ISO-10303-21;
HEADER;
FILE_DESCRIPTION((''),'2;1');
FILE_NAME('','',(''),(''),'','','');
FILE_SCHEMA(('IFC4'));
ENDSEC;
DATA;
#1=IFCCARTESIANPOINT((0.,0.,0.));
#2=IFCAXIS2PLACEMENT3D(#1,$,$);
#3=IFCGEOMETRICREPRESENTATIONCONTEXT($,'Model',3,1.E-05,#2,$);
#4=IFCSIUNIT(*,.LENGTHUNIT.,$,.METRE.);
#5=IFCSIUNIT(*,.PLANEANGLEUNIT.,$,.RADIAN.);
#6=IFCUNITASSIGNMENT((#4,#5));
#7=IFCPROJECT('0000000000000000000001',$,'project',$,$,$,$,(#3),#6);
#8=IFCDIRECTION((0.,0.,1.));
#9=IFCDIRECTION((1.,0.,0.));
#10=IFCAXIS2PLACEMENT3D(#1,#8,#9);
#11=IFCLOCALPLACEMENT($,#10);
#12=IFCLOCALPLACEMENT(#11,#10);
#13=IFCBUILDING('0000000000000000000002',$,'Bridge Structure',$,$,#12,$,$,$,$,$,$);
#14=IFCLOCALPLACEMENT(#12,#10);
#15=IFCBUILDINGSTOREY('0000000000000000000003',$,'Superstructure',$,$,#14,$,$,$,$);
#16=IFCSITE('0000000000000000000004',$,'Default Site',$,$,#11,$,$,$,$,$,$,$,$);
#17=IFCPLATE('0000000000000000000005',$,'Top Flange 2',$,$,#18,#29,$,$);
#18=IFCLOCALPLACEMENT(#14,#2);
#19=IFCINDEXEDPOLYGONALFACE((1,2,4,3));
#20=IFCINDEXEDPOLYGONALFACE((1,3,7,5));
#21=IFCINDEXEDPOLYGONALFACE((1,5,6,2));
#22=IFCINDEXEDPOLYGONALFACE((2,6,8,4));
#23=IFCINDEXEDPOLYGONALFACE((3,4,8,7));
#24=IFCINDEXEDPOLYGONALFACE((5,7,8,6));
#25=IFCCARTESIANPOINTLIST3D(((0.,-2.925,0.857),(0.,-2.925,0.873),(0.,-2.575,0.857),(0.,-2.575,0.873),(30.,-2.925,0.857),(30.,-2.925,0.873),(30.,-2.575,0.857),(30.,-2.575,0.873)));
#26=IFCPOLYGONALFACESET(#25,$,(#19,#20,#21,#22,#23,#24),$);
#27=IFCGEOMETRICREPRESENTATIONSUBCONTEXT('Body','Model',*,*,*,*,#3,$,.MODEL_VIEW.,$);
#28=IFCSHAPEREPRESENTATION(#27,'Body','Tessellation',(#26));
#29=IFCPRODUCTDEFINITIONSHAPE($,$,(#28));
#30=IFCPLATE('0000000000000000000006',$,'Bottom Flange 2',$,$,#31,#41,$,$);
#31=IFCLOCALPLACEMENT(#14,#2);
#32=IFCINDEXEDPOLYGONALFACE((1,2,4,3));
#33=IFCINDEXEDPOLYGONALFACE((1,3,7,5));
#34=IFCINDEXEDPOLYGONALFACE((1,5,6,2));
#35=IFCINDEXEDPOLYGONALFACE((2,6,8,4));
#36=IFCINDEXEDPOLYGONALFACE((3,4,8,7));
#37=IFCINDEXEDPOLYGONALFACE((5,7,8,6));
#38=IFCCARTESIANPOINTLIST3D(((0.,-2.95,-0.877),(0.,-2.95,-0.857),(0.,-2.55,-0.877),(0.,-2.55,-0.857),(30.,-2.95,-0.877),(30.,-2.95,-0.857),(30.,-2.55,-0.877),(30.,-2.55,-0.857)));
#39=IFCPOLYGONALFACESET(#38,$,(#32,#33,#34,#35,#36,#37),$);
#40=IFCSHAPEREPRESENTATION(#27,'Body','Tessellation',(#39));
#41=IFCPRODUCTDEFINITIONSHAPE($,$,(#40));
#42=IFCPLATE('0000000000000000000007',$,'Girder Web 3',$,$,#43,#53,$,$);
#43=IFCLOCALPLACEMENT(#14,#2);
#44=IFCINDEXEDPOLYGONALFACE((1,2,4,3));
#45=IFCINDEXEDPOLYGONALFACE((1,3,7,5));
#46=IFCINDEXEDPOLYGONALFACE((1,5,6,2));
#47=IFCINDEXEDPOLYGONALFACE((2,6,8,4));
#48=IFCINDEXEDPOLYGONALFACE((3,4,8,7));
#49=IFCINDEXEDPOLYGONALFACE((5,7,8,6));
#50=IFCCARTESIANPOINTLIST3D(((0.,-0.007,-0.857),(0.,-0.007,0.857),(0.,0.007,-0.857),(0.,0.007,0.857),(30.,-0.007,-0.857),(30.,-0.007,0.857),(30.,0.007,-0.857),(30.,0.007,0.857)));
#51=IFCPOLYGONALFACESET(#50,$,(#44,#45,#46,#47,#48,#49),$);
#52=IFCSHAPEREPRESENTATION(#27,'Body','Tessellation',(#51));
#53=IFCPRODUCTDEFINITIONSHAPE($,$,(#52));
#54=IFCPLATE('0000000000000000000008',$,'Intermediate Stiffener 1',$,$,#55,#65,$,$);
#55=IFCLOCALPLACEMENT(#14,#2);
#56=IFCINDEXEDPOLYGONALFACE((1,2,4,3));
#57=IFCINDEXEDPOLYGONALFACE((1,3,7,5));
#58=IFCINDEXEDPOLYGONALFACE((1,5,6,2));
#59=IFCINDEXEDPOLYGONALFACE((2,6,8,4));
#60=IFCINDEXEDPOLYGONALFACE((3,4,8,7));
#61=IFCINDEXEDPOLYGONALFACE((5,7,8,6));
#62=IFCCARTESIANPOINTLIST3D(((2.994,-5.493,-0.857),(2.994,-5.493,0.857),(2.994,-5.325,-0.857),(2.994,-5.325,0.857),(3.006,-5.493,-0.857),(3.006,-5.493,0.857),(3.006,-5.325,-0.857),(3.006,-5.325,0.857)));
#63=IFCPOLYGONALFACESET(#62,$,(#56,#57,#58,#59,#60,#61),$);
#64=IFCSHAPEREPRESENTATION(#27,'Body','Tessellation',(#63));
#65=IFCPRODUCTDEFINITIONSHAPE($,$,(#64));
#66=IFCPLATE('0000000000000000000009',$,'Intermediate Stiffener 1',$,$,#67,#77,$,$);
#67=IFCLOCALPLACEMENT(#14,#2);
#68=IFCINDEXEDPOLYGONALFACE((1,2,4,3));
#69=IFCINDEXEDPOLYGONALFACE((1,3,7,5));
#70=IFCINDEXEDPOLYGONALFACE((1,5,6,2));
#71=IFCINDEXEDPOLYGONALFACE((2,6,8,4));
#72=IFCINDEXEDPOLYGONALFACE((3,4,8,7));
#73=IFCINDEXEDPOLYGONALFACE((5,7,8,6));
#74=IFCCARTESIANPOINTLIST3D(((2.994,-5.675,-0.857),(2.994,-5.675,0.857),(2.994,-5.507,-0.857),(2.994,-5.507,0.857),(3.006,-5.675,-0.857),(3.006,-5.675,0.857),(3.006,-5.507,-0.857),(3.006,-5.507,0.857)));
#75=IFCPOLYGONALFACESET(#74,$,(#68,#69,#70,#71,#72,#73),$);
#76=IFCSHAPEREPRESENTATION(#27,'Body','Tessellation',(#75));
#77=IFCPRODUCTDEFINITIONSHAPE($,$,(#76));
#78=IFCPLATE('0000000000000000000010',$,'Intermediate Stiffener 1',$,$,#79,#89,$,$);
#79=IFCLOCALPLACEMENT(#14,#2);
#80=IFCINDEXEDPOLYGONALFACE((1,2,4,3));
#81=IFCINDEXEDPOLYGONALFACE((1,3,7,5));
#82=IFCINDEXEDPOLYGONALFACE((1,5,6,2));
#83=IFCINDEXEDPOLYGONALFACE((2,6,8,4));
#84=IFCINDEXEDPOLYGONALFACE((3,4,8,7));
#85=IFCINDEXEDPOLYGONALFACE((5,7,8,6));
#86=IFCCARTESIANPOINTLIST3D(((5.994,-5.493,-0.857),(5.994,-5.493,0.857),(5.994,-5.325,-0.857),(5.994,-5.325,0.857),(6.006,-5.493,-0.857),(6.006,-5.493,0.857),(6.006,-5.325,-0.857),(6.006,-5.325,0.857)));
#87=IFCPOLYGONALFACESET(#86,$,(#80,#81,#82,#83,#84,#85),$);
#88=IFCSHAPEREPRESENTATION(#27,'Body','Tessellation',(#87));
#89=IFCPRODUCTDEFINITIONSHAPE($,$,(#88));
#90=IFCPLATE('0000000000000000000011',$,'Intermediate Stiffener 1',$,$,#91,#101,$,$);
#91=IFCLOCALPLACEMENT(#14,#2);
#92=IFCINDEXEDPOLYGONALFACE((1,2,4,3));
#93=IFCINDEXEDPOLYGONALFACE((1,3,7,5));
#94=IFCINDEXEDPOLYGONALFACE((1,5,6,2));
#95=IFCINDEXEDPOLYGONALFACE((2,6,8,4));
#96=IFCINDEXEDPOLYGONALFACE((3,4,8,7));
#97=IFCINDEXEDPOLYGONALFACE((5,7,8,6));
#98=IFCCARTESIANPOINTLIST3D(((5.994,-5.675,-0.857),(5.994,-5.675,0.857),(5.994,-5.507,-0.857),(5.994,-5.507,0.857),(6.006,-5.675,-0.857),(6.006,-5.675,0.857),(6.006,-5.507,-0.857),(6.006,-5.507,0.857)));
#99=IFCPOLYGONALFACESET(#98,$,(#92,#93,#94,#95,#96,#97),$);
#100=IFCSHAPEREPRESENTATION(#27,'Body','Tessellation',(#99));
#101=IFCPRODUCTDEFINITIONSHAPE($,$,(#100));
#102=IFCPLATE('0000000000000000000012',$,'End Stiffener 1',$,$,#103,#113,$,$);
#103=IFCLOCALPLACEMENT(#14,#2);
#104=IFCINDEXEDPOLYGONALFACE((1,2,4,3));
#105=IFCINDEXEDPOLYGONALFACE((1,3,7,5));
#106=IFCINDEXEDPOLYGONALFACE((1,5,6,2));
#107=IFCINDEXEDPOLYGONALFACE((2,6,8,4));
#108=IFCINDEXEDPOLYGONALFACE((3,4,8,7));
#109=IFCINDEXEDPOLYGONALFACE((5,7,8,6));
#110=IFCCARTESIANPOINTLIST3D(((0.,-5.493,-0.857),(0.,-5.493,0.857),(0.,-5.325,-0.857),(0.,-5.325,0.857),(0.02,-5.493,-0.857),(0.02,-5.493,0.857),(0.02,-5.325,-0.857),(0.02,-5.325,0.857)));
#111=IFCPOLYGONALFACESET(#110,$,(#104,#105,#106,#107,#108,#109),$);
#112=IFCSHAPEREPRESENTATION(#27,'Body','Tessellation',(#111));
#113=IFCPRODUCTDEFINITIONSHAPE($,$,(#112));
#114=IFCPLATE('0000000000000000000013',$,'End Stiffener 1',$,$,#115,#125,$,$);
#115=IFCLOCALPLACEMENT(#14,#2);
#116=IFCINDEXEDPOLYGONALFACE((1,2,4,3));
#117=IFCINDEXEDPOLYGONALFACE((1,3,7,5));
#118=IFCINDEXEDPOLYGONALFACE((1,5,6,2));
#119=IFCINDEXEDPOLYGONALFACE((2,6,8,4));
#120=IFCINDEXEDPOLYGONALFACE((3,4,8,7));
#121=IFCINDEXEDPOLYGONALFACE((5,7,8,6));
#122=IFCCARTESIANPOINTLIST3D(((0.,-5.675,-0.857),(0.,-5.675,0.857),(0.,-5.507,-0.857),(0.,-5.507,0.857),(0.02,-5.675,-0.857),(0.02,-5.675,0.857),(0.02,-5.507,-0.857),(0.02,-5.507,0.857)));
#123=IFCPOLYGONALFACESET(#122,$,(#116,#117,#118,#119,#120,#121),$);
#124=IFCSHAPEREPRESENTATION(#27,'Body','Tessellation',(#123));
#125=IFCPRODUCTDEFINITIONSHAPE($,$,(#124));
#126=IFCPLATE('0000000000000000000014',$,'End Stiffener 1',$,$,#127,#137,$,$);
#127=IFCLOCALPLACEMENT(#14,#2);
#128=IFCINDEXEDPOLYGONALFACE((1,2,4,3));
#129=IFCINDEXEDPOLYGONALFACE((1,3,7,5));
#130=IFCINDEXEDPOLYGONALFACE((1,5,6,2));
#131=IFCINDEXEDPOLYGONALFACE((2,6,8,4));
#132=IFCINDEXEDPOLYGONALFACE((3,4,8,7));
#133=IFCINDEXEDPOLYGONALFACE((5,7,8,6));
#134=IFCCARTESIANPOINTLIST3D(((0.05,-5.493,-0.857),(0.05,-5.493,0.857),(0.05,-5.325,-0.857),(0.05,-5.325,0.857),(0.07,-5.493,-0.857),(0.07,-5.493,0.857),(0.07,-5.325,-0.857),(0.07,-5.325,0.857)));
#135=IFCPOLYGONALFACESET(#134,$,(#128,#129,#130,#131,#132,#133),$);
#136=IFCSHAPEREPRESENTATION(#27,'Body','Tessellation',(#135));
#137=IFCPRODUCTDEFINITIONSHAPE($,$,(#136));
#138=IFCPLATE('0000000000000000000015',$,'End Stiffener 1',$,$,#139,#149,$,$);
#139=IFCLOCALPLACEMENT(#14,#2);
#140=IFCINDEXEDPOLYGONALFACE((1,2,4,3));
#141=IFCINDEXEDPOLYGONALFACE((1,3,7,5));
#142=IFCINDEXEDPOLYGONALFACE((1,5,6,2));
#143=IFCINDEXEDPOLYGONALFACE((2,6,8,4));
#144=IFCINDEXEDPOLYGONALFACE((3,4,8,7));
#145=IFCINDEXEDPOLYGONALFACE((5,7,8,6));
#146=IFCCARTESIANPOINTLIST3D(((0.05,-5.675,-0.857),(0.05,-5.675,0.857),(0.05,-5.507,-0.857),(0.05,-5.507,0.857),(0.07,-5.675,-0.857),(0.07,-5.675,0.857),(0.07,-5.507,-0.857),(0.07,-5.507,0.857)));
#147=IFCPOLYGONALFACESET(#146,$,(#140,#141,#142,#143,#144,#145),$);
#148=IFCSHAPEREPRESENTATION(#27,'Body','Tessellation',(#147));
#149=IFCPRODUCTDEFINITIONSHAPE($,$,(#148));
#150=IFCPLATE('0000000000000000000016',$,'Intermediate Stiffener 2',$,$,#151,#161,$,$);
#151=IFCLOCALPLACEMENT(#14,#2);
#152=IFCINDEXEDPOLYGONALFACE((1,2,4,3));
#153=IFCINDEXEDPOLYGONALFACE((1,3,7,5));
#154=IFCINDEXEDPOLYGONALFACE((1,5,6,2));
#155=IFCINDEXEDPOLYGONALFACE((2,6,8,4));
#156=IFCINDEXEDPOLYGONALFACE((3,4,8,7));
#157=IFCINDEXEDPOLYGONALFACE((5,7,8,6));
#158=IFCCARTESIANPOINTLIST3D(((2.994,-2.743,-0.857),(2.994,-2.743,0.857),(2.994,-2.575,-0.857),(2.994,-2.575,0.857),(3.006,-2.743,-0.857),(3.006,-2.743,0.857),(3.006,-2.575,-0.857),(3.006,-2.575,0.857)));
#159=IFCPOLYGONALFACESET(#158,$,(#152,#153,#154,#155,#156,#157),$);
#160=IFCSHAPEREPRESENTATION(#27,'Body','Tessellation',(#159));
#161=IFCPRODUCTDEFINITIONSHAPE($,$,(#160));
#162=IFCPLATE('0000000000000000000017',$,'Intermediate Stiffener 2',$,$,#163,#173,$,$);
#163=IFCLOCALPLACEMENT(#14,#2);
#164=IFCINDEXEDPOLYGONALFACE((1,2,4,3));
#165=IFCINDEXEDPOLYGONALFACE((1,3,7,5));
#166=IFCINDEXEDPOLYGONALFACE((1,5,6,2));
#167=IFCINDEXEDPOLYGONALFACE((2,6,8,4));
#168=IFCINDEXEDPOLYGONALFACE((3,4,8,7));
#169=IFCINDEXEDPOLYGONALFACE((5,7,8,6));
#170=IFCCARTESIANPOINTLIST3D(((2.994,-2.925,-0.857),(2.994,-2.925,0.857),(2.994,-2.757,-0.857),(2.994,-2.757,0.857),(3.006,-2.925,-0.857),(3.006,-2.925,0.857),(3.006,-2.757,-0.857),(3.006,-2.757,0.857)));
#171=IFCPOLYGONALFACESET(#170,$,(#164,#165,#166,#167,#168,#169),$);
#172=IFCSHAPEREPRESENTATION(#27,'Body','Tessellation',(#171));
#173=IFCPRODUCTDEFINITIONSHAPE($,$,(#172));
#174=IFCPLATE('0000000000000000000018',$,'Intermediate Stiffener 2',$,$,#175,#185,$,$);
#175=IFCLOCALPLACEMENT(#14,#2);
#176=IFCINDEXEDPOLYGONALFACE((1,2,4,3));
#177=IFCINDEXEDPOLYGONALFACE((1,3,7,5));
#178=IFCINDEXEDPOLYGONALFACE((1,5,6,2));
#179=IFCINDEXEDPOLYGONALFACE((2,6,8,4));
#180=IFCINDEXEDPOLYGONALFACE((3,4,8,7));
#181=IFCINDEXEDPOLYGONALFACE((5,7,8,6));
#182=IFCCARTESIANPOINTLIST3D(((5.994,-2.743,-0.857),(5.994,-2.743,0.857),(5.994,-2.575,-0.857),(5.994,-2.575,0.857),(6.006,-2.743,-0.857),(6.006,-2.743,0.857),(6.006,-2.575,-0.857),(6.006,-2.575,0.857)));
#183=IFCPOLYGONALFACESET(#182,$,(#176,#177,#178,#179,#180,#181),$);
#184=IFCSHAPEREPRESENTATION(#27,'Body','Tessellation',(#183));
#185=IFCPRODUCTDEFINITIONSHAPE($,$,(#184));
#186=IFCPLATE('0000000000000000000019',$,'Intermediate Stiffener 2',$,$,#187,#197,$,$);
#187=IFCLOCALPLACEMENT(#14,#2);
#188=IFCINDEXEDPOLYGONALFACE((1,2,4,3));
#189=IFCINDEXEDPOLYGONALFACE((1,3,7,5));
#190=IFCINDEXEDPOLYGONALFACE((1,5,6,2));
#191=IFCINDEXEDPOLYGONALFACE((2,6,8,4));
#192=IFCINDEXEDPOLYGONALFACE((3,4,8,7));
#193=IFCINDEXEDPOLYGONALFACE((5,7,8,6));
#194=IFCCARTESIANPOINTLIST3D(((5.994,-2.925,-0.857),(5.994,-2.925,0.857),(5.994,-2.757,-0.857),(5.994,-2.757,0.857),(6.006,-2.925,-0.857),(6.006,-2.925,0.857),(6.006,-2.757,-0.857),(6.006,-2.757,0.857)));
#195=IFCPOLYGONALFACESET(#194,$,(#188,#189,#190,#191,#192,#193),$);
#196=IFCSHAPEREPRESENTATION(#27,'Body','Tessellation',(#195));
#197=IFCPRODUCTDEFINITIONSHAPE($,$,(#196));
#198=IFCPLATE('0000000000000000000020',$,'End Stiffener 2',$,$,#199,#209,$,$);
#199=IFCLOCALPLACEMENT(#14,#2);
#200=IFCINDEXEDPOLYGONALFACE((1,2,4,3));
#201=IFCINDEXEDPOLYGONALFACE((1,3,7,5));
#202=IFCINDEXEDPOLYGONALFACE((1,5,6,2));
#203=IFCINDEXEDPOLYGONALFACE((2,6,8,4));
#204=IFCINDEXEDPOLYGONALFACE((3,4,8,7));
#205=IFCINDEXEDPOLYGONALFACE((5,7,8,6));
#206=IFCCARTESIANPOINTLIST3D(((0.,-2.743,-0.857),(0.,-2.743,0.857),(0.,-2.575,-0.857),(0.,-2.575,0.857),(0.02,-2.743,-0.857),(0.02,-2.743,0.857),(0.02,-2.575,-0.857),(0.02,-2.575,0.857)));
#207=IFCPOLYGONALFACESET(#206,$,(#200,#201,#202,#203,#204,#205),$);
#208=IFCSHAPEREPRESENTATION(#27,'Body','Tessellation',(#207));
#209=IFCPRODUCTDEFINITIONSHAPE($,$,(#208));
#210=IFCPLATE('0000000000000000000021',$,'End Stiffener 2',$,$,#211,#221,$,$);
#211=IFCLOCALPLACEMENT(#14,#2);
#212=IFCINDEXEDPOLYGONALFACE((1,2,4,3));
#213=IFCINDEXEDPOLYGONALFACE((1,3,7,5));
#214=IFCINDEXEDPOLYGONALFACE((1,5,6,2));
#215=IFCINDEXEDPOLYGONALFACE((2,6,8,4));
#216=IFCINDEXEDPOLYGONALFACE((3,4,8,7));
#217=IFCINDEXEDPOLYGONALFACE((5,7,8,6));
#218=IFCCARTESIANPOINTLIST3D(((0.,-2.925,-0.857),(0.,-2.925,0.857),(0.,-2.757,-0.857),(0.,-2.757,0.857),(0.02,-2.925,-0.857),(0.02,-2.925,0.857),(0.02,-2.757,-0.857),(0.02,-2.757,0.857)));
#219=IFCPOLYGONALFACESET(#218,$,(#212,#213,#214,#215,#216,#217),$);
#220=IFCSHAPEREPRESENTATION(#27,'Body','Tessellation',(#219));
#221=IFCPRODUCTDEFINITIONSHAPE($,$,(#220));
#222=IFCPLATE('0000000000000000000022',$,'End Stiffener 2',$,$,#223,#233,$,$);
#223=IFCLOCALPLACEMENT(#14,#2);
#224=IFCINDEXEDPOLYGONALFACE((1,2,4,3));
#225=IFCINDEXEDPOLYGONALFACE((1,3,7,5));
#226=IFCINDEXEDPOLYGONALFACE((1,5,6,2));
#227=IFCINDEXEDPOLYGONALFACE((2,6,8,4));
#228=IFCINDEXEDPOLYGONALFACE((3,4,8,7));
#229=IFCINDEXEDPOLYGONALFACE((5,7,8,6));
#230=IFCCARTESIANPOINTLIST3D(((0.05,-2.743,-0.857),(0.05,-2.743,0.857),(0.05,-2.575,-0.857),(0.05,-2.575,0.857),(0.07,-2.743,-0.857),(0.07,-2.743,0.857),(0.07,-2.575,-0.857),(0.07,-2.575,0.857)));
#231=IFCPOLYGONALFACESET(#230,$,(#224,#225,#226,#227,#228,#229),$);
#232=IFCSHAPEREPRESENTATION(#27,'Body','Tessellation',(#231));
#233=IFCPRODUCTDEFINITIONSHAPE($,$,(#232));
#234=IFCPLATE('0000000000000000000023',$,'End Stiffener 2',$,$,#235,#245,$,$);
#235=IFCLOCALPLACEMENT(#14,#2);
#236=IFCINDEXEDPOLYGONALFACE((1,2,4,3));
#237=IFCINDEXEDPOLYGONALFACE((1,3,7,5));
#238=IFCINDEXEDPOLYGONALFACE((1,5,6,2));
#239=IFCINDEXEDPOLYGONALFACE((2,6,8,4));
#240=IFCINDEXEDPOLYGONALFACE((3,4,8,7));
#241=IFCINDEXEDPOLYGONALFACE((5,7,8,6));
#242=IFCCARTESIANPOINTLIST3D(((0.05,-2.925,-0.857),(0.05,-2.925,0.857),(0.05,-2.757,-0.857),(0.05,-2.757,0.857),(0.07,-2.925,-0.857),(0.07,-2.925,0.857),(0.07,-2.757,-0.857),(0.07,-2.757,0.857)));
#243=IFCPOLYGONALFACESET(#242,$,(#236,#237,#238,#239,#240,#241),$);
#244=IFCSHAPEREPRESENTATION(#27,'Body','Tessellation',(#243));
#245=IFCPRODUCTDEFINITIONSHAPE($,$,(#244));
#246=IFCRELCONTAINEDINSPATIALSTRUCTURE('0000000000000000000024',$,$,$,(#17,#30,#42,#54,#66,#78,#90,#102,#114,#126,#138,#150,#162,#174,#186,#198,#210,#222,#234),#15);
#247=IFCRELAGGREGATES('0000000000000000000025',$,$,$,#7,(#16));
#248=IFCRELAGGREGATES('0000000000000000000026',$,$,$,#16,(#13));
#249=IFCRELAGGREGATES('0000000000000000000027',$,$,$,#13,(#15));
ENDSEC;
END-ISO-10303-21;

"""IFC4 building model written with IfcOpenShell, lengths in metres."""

from ifc_helpers import new_model, si_unit, frame, origin, origin_with_axes, origin_2d_with_axis, place, context, subcontext, project, spatial, rectangle, extrude, element, save


model = new_model("IFC4")

# Units and contexts
model_context = context("Model", 3, precision=1e-05, world=origin())
body_context = subcontext(model_context, "Body", "Model", "MODEL_VIEW")
ifc_project = project(units=[si_unit("LENGTHUNIT", "METRE"), si_unit("PLANEANGLEUNIT", "RADIAN")], contexts=[model_context])

# Site, building, storey
site_placement = place(None, origin_with_axes())
site = spatial("IfcSite", under=ifc_project, at=site_placement, Name="Default Site")
building_placement = place(site_placement, origin_with_axes())
building = spatial("IfcBuilding", under=site, at=building_placement, Name="Bridge Structure")
storey_placement = place(building_placement, origin_with_axes())
storey = spatial("IfcBuildingStorey", under=building, at=storey_placement, Name="Superstructure")

# Plates
plate_1_placement = place(storey_placement, frame((0.0, -2.75, 0.865), z_axis=(1.0, 0.0, 0.0), x_axis=(0.0, 1.0, 0.0)))
element("IfcPlate", 1, at=plate_1_placement, inside=storey, Name="Top Flange 2", context=body_context, shape_type="SweptSolid", body=[
    extrude(rectangle(XDim=0.35, YDim=0.016, at=origin_2d_with_axis()), origin_with_axes(), (0.0, 0.0, 1.0), 30.0),
])
plate_2_placement = place(storey_placement, frame((0.0, -2.75, -0.867), z_axis=(1.0, 0.0, 0.0), x_axis=(0.0, 1.0, 0.0)))
element("IfcPlate", 2, at=plate_2_placement, inside=storey, Name="Bottom Flange 2", context=body_context, shape_type="SweptSolid", body=[
    extrude(rectangle(XDim=0.4, YDim=0.02, at=origin_2d_with_axis()), origin_with_axes(), (0.0, 0.0, 1.0), 30.0),
])
plate_3_placement = place(storey_placement, frame((0.0, 0.0, 0.0), z_axis=(1.0, 0.0, 0.0), x_axis=(0.0, 1.0, 0.0)))
element("IfcPlate", 3, at=plate_3_placement, inside=storey, Name="Girder Web 3", context=body_context, shape_type="SweptSolid", body=[
    extrude(rectangle(XDim=0.014, YDim=1.714, at=origin_2d_with_axis()), origin_with_axes(), (0.0, 0.0, 1.0), 30.0),
])
for number, where, z_axis, x_axis, name in (
    (4, (3.0, -5.409, -0.857), (0.0, 0.0, 1.0), (1.0, 0.0, 0.0), "Intermediate Stiffener 1"),
    (5, (3.0, -5.591, -0.857), (0.0, 0.0, 1.0), (1.0, 0.0, 0.0), "Intermediate Stiffener 1"),
    (6, (6.0, -5.409, -0.857), (0.0, 0.0, 1.0), (1.0, 0.0, 0.0), "Intermediate Stiffener 1"),
    (7, (6.0, -5.591, -0.857), (0.0, 0.0, 1.0), (1.0, 0.0, 0.0), "Intermediate Stiffener 1"),
):
    element("IfcPlate", number, at=place(storey_placement, frame(where, z_axis=z_axis, x_axis=x_axis)), inside=storey, Name=name, context=body_context, shape_type="SweptSolid", body=[
        extrude(rectangle(XDim=0.012, YDim=0.168, at=origin_2d_with_axis()), origin_with_axes(), (0.0, 0.0, 1.0), 1.714),
    ])
for number, where, z_axis, x_axis, name in (
    (8, (0.01, -5.409, -0.857), (0.0, 0.0, 1.0), (1.0, 0.0, 0.0), "End Stiffener 1"),
    (9, (0.01, -5.591, -0.857), (0.0, 0.0, 1.0), (1.0, 0.0, 0.0), "End Stiffener 1"),
    (10, (0.06, -5.409, -0.857), (0.0, 0.0, 1.0), (1.0, 0.0, 0.0), "End Stiffener 1"),
    (11, (0.06, -5.591, -0.857), (0.0, 0.0, 1.0), (1.0, 0.0, 0.0), "End Stiffener 1"),
):
    element("IfcPlate", number, at=place(storey_placement, frame(where, z_axis=z_axis, x_axis=x_axis)), inside=storey, Name=name, context=body_context, shape_type="SweptSolid", body=[
        extrude(rectangle(XDim=0.02, YDim=0.168, at=origin_2d_with_axis()), origin_with_axes(), (0.0, 0.0, 1.0), 1.714),
    ])
for number, where, z_axis, x_axis, name in (
    (12, (3.0, -2.659, -0.857), (0.0, 0.0, 1.0), (1.0, 0.0, 0.0), "Intermediate Stiffener 2"),
    (13, (3.0, -2.841, -0.857), (0.0, 0.0, 1.0), (1.0, 0.0, 0.0), "Intermediate Stiffener 2"),
    (14, (6.0, -2.659, -0.857), (0.0, 0.0, 1.0), (1.0, 0.0, 0.0), "Intermediate Stiffener 2"),
    (15, (6.0, -2.841, -0.857), (0.0, 0.0, 1.0), (1.0, 0.0, 0.0), "Intermediate Stiffener 2"),
):
    element("IfcPlate", number, at=place(storey_placement, frame(where, z_axis=z_axis, x_axis=x_axis)), inside=storey, Name=name, context=body_context, shape_type="SweptSolid", body=[
        extrude(rectangle(XDim=0.012, YDim=0.168, at=origin_2d_with_axis()), origin_with_axes(), (0.0, 0.0, 1.0), 1.714),
    ])
for number, where, z_axis, x_axis, name in (
    (16, (0.01, -2.659, -0.857), (0.0, 0.0, 1.0), (1.0, 0.0, 0.0), "End Stiffener 2"),
    (17, (0.01, -2.841, -0.857), (0.0, 0.0, 1.0), (1.0, 0.0, 0.0), "End Stiffener 2"),
    (18, (0.06, -2.659, -0.857), (0.0, 0.0, 1.0), (1.0, 0.0, 0.0), "End Stiffener 2"),
    (19, (0.06, -2.841, -0.857), (0.0, 0.0, 1.0), (1.0, 0.0, 0.0), "End Stiffener 2"),
):
    element("IfcPlate", number, at=place(storey_placement, frame(where, z_axis=z_axis, x_axis=x_axis)), inside=storey, Name=name, context=body_context, shape_type="SweptSolid", body=[
        extrude(rectangle(XDim=0.02, YDim=0.168, at=origin_2d_with_axis()), origin_with_axes(), (0.0, 0.0, 1.0), 1.714),
    ])

save(model, "model.ifc")
